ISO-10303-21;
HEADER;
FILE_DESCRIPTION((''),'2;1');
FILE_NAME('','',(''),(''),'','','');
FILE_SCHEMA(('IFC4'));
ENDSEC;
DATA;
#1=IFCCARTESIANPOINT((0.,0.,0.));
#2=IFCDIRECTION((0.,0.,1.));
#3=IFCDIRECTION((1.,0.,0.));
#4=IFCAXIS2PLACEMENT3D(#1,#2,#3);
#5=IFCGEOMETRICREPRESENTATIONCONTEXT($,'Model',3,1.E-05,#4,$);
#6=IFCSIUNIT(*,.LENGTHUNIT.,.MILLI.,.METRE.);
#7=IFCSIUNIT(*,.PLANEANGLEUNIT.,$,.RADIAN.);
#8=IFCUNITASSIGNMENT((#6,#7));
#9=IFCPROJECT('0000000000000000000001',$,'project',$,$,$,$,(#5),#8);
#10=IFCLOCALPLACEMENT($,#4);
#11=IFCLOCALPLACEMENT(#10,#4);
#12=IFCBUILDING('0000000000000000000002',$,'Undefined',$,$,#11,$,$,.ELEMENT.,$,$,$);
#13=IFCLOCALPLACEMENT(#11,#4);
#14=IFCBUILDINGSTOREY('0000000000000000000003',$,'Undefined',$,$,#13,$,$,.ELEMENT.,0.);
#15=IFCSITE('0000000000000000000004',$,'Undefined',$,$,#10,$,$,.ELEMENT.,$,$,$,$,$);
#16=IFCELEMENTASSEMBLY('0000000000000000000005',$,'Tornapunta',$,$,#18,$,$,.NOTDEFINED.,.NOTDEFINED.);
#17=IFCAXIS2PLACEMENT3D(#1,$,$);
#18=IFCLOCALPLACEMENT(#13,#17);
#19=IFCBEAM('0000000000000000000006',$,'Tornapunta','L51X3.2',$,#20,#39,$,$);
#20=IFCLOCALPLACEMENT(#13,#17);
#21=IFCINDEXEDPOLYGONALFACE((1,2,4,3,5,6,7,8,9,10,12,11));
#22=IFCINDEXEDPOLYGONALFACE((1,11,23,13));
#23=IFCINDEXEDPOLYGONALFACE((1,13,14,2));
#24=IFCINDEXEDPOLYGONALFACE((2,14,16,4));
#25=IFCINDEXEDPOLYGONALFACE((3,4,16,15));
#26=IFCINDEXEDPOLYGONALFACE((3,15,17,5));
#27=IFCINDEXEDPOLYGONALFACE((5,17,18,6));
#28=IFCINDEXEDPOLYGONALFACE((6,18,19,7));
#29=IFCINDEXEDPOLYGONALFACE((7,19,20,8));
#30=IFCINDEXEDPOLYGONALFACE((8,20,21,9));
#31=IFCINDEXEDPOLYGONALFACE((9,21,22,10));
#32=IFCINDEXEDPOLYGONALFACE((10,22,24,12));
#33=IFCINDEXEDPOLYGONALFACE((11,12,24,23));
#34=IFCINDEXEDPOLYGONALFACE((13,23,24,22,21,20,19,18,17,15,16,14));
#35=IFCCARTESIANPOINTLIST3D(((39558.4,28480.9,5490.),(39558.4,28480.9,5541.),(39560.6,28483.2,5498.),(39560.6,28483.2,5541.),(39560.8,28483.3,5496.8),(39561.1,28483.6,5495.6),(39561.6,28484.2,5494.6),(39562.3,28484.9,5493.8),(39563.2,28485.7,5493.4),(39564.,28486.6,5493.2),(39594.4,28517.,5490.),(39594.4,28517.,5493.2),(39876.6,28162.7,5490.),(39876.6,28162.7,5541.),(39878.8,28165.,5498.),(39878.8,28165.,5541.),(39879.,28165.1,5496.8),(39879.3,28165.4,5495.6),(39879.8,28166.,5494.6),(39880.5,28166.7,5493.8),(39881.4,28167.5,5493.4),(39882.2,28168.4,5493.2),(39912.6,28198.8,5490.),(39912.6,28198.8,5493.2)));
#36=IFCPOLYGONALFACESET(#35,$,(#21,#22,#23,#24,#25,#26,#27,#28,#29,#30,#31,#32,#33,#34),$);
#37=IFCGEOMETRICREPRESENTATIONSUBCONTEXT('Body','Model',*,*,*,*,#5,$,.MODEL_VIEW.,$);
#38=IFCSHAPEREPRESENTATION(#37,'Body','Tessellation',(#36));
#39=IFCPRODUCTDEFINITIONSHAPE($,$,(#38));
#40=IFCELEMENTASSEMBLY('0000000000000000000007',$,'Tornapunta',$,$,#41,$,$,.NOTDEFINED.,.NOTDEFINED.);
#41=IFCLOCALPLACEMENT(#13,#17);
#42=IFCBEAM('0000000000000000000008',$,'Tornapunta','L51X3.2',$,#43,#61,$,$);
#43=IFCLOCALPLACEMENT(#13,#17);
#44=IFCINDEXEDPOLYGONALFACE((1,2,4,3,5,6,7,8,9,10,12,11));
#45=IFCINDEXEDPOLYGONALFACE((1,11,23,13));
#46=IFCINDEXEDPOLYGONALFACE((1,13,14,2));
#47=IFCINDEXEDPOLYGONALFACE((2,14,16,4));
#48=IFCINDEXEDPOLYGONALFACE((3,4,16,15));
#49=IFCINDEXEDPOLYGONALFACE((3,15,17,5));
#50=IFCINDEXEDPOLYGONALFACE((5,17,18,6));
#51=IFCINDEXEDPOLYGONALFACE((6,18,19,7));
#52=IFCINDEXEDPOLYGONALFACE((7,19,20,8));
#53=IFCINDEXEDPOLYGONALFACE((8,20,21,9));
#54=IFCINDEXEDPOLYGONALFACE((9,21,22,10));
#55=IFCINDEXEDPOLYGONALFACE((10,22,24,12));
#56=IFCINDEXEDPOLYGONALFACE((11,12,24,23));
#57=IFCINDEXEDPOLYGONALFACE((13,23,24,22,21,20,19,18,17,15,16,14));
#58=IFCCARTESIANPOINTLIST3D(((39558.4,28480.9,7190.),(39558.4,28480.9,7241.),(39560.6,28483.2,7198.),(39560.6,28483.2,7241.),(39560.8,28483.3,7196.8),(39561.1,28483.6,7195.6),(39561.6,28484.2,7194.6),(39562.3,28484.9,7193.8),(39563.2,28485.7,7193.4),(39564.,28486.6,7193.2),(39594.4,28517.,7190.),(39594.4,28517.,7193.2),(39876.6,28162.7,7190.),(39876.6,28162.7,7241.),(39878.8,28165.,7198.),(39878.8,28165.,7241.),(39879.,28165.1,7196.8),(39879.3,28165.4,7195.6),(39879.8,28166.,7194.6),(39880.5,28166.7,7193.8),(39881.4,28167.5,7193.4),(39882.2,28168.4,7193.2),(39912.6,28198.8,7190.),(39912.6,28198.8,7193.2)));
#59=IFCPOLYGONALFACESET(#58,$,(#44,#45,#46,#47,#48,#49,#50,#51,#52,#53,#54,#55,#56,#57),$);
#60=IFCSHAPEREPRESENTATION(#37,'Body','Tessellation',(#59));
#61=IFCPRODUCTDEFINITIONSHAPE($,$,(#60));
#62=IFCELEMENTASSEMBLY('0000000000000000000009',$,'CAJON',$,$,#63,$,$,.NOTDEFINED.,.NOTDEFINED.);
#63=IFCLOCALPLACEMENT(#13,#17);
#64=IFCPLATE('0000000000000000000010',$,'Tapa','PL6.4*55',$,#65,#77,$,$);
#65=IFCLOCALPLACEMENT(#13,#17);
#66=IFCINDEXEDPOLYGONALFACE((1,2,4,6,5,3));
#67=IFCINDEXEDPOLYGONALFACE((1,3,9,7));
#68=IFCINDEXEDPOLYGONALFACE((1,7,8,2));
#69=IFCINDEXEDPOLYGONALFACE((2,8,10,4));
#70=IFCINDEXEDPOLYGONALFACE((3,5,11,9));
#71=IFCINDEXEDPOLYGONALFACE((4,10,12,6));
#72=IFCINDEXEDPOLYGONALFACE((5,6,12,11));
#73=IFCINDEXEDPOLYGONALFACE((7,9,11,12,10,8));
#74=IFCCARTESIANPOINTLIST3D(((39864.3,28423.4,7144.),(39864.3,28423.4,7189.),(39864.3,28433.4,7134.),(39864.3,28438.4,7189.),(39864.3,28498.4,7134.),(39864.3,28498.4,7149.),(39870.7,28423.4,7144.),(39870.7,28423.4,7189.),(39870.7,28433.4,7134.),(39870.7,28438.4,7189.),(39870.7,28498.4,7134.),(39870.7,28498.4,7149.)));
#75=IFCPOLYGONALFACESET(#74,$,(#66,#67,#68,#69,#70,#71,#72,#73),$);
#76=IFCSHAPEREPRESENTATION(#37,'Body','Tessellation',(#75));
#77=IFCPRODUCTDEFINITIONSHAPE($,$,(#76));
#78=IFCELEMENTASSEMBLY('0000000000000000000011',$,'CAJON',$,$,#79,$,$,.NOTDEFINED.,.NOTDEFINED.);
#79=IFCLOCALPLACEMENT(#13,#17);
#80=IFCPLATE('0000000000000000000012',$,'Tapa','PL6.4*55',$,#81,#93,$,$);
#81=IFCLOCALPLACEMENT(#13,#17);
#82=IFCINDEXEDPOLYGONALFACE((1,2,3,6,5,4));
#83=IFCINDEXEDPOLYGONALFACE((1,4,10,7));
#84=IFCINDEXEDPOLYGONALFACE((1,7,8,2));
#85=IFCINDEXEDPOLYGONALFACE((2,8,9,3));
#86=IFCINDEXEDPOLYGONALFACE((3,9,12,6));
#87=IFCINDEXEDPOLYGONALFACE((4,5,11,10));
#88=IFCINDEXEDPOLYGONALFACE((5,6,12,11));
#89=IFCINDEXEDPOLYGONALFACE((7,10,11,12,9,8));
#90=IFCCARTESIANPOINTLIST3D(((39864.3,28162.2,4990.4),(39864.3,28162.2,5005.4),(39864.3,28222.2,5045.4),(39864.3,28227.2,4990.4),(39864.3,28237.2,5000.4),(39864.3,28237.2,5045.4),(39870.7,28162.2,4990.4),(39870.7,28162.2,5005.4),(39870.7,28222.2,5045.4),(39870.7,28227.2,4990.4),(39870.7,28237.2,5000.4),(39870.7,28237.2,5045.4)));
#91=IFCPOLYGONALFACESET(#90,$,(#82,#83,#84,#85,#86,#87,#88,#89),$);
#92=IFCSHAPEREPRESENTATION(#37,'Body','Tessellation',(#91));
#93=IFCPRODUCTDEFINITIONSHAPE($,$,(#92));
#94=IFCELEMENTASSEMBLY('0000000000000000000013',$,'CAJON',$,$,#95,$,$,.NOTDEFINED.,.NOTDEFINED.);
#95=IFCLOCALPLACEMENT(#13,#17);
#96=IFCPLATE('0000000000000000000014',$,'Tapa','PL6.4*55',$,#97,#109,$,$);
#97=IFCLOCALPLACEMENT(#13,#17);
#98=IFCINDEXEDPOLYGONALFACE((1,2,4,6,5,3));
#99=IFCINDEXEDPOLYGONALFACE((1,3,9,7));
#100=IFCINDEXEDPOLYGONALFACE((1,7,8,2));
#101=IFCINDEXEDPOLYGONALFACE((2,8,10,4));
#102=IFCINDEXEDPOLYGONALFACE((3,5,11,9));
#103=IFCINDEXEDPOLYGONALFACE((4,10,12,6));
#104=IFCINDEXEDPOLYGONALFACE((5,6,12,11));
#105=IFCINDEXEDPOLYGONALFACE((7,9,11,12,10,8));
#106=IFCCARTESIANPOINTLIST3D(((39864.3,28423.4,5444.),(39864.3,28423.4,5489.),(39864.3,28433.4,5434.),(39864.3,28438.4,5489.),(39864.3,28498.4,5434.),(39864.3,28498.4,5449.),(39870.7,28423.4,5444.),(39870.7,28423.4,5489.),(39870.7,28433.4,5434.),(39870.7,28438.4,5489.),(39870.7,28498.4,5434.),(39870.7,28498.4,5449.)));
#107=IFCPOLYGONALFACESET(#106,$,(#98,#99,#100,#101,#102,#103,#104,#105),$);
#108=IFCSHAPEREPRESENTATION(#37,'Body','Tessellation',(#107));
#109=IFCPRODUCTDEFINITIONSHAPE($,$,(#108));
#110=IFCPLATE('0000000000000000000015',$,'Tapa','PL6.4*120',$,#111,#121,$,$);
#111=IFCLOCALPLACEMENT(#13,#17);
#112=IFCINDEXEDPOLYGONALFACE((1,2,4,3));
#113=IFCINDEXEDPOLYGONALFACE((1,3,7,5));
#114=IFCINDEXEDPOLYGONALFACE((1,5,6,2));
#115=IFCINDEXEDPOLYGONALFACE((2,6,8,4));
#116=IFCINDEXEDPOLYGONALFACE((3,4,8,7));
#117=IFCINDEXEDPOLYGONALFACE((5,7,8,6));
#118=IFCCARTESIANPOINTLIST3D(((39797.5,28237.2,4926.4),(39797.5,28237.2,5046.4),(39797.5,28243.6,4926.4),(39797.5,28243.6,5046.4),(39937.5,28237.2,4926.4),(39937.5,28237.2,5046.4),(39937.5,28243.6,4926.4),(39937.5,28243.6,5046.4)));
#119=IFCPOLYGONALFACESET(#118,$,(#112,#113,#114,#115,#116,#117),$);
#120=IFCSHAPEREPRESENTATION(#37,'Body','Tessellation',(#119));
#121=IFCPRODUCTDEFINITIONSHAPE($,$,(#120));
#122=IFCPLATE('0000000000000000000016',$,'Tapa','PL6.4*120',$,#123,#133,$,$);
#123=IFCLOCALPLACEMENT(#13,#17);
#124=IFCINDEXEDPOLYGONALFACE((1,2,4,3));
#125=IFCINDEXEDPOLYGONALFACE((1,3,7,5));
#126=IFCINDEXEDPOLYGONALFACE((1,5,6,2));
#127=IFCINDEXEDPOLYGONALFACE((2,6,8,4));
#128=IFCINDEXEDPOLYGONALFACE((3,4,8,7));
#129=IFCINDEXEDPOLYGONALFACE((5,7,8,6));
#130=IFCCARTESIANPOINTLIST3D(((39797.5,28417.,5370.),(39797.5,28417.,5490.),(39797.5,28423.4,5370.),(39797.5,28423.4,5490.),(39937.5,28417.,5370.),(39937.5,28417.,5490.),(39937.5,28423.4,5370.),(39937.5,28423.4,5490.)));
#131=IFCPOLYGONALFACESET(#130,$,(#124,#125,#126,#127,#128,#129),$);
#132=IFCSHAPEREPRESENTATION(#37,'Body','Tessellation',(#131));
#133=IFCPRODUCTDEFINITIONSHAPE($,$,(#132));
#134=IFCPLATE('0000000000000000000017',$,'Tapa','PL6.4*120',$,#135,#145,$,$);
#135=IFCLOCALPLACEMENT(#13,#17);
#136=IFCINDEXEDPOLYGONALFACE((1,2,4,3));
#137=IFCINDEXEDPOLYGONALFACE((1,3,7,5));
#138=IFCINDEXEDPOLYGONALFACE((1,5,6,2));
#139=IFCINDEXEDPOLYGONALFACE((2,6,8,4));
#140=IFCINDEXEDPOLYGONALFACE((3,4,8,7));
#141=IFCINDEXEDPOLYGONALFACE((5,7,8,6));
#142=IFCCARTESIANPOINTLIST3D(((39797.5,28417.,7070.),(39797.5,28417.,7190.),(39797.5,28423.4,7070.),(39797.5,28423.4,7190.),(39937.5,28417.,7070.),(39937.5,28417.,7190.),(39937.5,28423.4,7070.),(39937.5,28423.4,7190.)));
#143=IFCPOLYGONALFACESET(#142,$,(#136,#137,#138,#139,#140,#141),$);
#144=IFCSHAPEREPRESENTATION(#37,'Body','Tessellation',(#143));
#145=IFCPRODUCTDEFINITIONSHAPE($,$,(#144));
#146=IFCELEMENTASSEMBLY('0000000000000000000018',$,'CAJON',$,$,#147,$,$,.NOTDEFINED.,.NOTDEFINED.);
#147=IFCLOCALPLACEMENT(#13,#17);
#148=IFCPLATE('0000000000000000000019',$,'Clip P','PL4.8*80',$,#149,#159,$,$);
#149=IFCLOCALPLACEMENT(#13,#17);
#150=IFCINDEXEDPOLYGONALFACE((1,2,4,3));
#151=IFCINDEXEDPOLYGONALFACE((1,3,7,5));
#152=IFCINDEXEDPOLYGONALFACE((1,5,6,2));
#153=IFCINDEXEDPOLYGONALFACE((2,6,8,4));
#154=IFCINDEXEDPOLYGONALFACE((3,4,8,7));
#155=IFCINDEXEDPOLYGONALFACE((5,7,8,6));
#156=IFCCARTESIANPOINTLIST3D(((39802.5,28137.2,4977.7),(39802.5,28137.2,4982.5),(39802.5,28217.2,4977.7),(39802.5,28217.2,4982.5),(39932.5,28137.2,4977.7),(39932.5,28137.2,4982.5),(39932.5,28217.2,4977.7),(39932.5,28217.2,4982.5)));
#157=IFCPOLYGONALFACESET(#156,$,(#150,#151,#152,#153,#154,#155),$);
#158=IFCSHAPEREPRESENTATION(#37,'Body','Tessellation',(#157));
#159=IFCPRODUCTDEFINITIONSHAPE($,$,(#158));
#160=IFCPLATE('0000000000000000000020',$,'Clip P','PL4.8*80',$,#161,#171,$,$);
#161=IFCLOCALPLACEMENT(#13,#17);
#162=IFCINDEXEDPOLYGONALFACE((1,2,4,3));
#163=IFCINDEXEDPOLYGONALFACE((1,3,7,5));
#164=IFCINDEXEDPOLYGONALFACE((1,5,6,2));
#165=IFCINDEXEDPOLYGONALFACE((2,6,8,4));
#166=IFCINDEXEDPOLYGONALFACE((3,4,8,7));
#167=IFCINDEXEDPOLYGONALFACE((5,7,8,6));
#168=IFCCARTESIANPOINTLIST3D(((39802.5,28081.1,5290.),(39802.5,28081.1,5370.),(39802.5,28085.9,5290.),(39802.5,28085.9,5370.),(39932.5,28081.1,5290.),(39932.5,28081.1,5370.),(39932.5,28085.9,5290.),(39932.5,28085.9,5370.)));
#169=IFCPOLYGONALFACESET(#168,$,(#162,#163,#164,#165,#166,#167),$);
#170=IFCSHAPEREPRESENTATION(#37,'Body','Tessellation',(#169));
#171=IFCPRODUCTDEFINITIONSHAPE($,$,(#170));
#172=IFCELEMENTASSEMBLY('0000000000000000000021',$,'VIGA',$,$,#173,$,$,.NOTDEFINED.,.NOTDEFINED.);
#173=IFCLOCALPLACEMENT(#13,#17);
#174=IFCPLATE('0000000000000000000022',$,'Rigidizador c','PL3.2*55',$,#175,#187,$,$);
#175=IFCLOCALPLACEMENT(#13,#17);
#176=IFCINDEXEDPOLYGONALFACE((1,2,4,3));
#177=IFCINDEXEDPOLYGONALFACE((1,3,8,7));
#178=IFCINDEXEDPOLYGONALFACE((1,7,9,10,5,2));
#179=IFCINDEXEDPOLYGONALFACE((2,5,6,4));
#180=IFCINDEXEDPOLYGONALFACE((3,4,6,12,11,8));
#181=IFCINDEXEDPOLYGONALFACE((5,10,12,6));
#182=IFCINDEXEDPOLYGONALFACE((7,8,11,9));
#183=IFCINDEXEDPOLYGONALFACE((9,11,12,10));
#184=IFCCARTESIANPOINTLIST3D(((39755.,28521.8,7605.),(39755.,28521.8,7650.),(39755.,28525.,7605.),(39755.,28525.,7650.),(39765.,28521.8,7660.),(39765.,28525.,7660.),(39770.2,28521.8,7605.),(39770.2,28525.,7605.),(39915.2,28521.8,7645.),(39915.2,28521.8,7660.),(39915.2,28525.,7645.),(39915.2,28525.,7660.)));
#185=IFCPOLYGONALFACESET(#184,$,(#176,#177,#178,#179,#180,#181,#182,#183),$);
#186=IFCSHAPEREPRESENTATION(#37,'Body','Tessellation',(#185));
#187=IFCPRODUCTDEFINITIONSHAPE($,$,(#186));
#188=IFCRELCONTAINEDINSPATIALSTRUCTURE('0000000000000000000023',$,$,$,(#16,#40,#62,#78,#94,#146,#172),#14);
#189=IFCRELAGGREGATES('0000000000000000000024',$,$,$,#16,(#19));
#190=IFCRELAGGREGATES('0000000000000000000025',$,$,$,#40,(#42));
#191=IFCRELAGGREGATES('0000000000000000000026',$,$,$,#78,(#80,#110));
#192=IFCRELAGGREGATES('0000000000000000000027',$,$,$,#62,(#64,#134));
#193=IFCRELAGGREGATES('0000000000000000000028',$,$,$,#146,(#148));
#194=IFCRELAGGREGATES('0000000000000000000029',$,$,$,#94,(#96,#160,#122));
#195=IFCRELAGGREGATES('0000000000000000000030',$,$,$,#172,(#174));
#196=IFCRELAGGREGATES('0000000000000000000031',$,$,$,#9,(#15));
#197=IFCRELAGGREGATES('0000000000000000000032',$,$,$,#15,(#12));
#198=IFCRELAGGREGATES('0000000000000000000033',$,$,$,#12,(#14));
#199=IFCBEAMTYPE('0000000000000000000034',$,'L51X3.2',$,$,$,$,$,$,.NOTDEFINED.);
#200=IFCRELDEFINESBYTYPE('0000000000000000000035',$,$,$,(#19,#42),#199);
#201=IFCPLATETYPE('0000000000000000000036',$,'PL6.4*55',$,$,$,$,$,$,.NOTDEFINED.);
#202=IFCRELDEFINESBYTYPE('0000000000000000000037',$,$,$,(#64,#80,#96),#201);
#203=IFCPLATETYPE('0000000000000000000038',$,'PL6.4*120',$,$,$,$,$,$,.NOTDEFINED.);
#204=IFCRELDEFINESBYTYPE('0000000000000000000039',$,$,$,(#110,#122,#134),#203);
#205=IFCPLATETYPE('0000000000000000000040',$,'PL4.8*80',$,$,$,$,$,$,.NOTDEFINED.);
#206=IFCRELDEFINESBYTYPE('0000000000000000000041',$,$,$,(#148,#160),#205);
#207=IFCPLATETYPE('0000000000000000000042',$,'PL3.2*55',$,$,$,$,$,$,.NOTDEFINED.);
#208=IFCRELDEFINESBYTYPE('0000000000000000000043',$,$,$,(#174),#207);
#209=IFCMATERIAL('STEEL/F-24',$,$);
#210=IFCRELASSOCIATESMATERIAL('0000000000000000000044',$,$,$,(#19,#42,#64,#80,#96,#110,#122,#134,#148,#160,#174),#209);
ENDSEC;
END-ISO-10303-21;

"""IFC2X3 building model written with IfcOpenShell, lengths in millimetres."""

from ifc_helpers import new_model, si_unit, frame, origin_with_axes, origin_2d_with_axis, place, context, subcontext, project, spatial, polyline, l_section, outline, extrude, material, type_object, element, aggregate, save


model = new_model("IFC2X3")

# Units and contexts
model_context = context("Model", 3, precision=1e-05, world=origin_with_axes())
body_context = subcontext(model_context, "Body", "Model", "MODEL_VIEW")
ifc_project = project(units=[si_unit("LENGTHUNIT", "METRE", prefix="MILLI"), si_unit("PLANEANGLEUNIT", "RADIAN")], contexts=[model_context])

# Site, building, storey
site_placement = place(None, origin_with_axes())
site = spatial("IfcSite", under=ifc_project, at=site_placement, Name="Undefined", CompositionType="ELEMENT")
building_placement = place(site_placement, origin_with_axes())
building = spatial("IfcBuilding", under=site, at=building_placement, Name="Undefined", CompositionType="ELEMENT")
storey_placement = place(building_placement, origin_with_axes())
storey = spatial("IfcBuildingStorey", under=building, at=storey_placement, Name="Undefined", CompositionType="ELEMENT", Elevation=0.0)

# Element assemblies, beams
assembly_1_placement = place(storey_placement, origin_with_axes())
assembly_1 = element("IfcElementAssembly", 1, at=assembly_1_placement, inside=storey, Name="Tornapunta", AssemblyPlace="NOTDEFINED", PredefinedType="NOTDEFINED")
ifc_material_1 = material(Name="STEEL/F-24")
beam_type = type_object("IfcBeamType", Name="L51X3.2", PredefinedType="NOTDEFINED")
beam_1_placement = place(assembly_1_placement, frame((39894.6, 28180.7, 5515.5), z_axis=(0.0, 0.0, 1.0), x_axis=(-0.707107, 0.707107, 0.0)))
beam_1 = element("IfcBeam", 2, at=beam_1_placement, type_object=beam_type, material=ifc_material_1, Name="Tornapunta", Description="L51X3.2", context=body_context, shape_type="SweptSolid", body=[
    extrude(l_section(Depth=51.0, Width=51.0, Thickness=3.2, FilletRadius=4.8, at=origin_2d_with_axis()), frame((450.0, 0.0, 0.0), z_axis=(-1.0, 0.0, 0.0), x_axis=(0.0, -1.0, 0.0)), (0.0, 0.0, 1.0), 450.0),
])
aggregate(assembly_1, [beam_1])
assembly_2_placement = place(storey_placement, origin_with_axes())
assembly_2 = element("IfcElementAssembly", 3, at=assembly_2_placement, inside=storey, Name="Tornapunta", AssemblyPlace="NOTDEFINED", PredefinedType="NOTDEFINED")
beam_2_placement = place(assembly_2_placement, frame((39894.6, 28180.7, 7215.5), z_axis=(0.0, 0.0, 1.0), x_axis=(-0.707107, 0.707107, 0.0)))
beam_2 = element("IfcBeam", 4, at=beam_2_placement, type_object=beam_type, material=ifc_material_1, Name="Tornapunta", Description="L51X3.2", context=body_context, shape_type="SweptSolid", body=[
    extrude(l_section(Depth=51.0, Width=51.0, Thickness=3.2, FilletRadius=4.8, at=origin_2d_with_axis()), frame((450.0, 0.0, 0.0), z_axis=(-1.0, 0.0, 0.0), x_axis=(0.0, -1.0, 0.0)), (0.0, 0.0, 1.0), 450.0),
])
aggregate(assembly_2, [beam_2])

# Element assemblies, plates
assembly_3_placement = place(storey_placement, origin_with_axes())
assembly_3 = element("IfcElementAssembly", 5, at=assembly_3_placement, inside=storey, Name="CAJON", AssemblyPlace="NOTDEFINED", PredefinedType="NOTDEFINED")
plate_type_1 = type_object("IfcPlateType", Name="PL6.4*55", PredefinedType="NOTDEFINED")
plate_1_placement = place(assembly_3_placement, frame((39867.5, 28498.4, 7134.0), z_axis=(-1.0, 0.0, 0.0), x_axis=(0.0, -1.0, 0.0)))
plate_1 = element("IfcPlate", 6, at=plate_1_placement, type_object=plate_type_1, material=ifc_material_1, Name="Tapa", Description="PL6.4*55", context=body_context, shape_type="SweptSolid", body=[
    extrude(outline(polyline([(0.0, 0.0), (65.0, 0.0), (75.0, 10.0), (75.0, 55.0), (60.0, 55.0), (0.0, 15.0), (0.0, 0.0)])), frame((0.0, 0.0, -3.2), z_axis=(0.0, 0.0, 1.0), x_axis=(1.0, 0.0, 0.0)), (0.0, 0.0, 1.0), 6.4),
])
assembly_4_placement = place(storey_placement, origin_with_axes())
assembly_4 = element("IfcElementAssembly", 7, at=assembly_4_placement, inside=storey, Name="CAJON", AssemblyPlace="NOTDEFINED", PredefinedType="NOTDEFINED")
plate_2_placement = place(assembly_4_placement, frame((39867.5, 28162.2, 4990.4), z_axis=(1.0, 0.0, 0.0), x_axis=(0.0, 1.0, 0.0)))
plate_2 = element("IfcPlate", 8, at=plate_2_placement, type_object=plate_type_1, material=ifc_material_1, Name="Tapa", Description="PL6.4*55", context=body_context, shape_type="SweptSolid", body=[
    extrude(outline(polyline([(0.0, 0.0), (65.0, 0.0), (75.0, 10.0), (75.0, 55.0), (60.0, 55.0), (0.0, 15.0), (0.0, 0.0)])), frame((0.0, 0.0, -3.2), z_axis=(0.0, 0.0, 1.0), x_axis=(1.0, 0.0, 0.0)), (0.0, 0.0, 1.0), 6.4),
])
assembly_5_placement = place(storey_placement, origin_with_axes())
assembly_5 = element("IfcElementAssembly", 9, at=assembly_5_placement, inside=storey, Name="CAJON", AssemblyPlace="NOTDEFINED", PredefinedType="NOTDEFINED")
plate_3_placement = place(assembly_5_placement, frame((39867.5, 28498.4, 5434.0), z_axis=(-1.0, 0.0, 0.0), x_axis=(0.0, -1.0, 0.0)))
plate_3 = element("IfcPlate", 10, at=plate_3_placement, type_object=plate_type_1, material=ifc_material_1, Name="Tapa", Description="PL6.4*55", context=body_context, shape_type="SweptSolid", body=[
    extrude(outline(polyline([(0.0, 0.0), (65.0, 0.0), (75.0, 10.0), (75.0, 55.0), (60.0, 55.0), (0.0, 15.0), (0.0, 0.0)])), frame((0.0, 0.0, -3.2), z_axis=(0.0, 0.0, 1.0), x_axis=(1.0, 0.0, 0.0)), (0.0, 0.0, 1.0), 6.4),
])

# Plates
plate_type_2 = type_object("IfcPlateType", Name="PL6.4*120", PredefinedType="NOTDEFINED")
plate_4_placement = place(assembly_4_placement, frame((39937.5, 28240.4, 5046.4), z_axis=(0.0, 1.0, 0.0), x_axis=(0.0, 0.0, -1.0)))
plate_4 = element("IfcPlate", 11, at=plate_4_placement, type_object=plate_type_2, material=ifc_material_1, Name="Tapa", Description="PL6.4*120", context=body_context, shape_type="SweptSolid", body=[
    extrude(outline(polyline([(0.0, 0.0), (120.0, 0.0), (120.0, 140.0), (0.0, 140.0), (0.0, 0.0)])), frame((0.0, 0.0, -3.2), z_axis=(0.0, 0.0, 1.0), x_axis=(1.0, 0.0, 0.0)), (0.0, 0.0, 1.0), 6.4),
])
aggregate(assembly_4, [plate_2, plate_4])
plate_5_placement = place(assembly_5_placement, frame((39937.5, 28420.2, 5490.0), z_axis=(0.0, 1.0, 0.0), x_axis=(0.0, 0.0, -1.0)))
plate_5 = element("IfcPlate", 12, at=plate_5_placement, type_object=plate_type_2, material=ifc_material_1, Name="Tapa", Description="PL6.4*120", context=body_context, shape_type="SweptSolid", body=[
    extrude(outline(polyline([(0.0, 0.0), (120.0, 0.0), (120.0, 140.0), (0.0, 140.0), (0.0, 0.0)])), frame((0.0, 0.0, -3.2), z_axis=(0.0, 0.0, 1.0), x_axis=(1.0, 0.0, 0.0)), (0.0, 0.0, 1.0), 6.4),
])
plate_6_placement = place(assembly_3_placement, frame((39937.5, 28420.2, 7190.0), z_axis=(0.0, 1.0, 0.0), x_axis=(0.0, 0.0, -1.0)))
plate_6 = element("IfcPlate", 13, at=plate_6_placement, type_object=plate_type_2, material=ifc_material_1, Name="Tapa", Description="PL6.4*120", context=body_context, shape_type="SweptSolid", body=[
    extrude(outline(polyline([(0.0, 0.0), (120.0, 0.0), (120.0, 140.0), (0.0, 140.0), (0.0, 0.0)])), frame((0.0, 0.0, -3.2), z_axis=(0.0, 0.0, 1.0), x_axis=(1.0, 0.0, 0.0)), (0.0, 0.0, 1.0), 6.4),
])
aggregate(assembly_3, [plate_1, plate_6])

# Element assembly, plate
assembly_6_placement = place(storey_placement, origin_with_axes())
assembly_6 = element("IfcElementAssembly", 14, at=assembly_6_placement, inside=storey, Name="CAJON", AssemblyPlace="NOTDEFINED", PredefinedType="NOTDEFINED")
plate_type_3 = type_object("IfcPlateType", Name="PL4.8*80", PredefinedType="NOTDEFINED")
plate_7_placement = place(assembly_6_placement, frame((39802.5, 28217.2, 4980.1), z_axis=(0.0, -0.000013, -1.0), x_axis=(1.0, 0.0, 0.0)))
plate_7 = element("IfcPlate", 15, at=plate_7_placement, type_object=plate_type_3, material=ifc_material_1, Name="Clip P", Description="PL4.8*80", context=body_context, shape_type="SweptSolid", body=[
    extrude(outline(polyline([(0.0, 0.0), (130.0, 0.0), (130.0, 80.0), (0.0, 80.0), (0.0, 0.0)])), frame((0.0, 0.0, -2.4), z_axis=(0.0, 0.0, 1.0), x_axis=(1.0, 0.0, 0.0)), (0.0, 0.0, 1.0), 4.8),
])

# Plate
plate_8_placement = place(assembly_5_placement, frame((39802.5, 28083.5, 5290.0), z_axis=(0.0, -1.0, -0.000052), x_axis=(1.0, 0.0, 0.0)))
plate_8 = element("IfcPlate", 16, at=plate_8_placement, type_object=plate_type_3, material=ifc_material_1, Name="Clip P", Description="PL4.8*80", context=body_context, shape_type="SweptSolid", body=[
    extrude(outline(polyline([(0.0, 0.0), (130.0, 0.0), (130.0, 80.0), (0.0, 80.0), (0.0, 0.0)])), frame((0.0, 0.0, -2.4), z_axis=(0.0, 0.0, 1.0), x_axis=(1.0, 0.0, 0.0)), (0.0, 0.0, 1.0), 4.8),
])

# Element assembly, plate
assembly_7_placement = place(storey_placement, origin_with_axes())
assembly_7 = element("IfcElementAssembly", 17, at=assembly_7_placement, inside=storey, Name="VIGA", AssemblyPlace="NOTDEFINED", PredefinedType="NOTDEFINED")
plate_type_4 = type_object("IfcPlateType", Name="PL3.2*55", PredefinedType="NOTDEFINED")
plate_9_placement = place(assembly_7_placement, frame((39915.2, 28523.4, 7660.0), z_axis=(0.0, 1.0, 0.0), x_axis=(0.000001, 0.0, -1.0)))
plate_9 = element("IfcPlate", 18, at=plate_9_placement, type_object=plate_type_4, material=ifc_material_1, Name="Rigidizador c", Description="PL3.2*55", context=body_context, shape_type="SweptSolid", body=[
    extrude(outline(polyline([(0.0, 0.0), (15.0, 0.0), (55.0, 145.0), (55.0, 160.2), (10.0, 160.2), (0.0, 150.2), (0.0, 0.0)])), frame((0.0, 0.0, -1.6), z_axis=(0.0, 0.0, 1.0), x_axis=(1.0, 0.0, 0.0)), (0.0, 0.0, 1.0), 3.2),
])

aggregate(assembly_6, [plate_7])
aggregate(assembly_5, [plate_3, plate_8, plate_5])
aggregate(assembly_7, [plate_9])

save(model, "model.ifc")
